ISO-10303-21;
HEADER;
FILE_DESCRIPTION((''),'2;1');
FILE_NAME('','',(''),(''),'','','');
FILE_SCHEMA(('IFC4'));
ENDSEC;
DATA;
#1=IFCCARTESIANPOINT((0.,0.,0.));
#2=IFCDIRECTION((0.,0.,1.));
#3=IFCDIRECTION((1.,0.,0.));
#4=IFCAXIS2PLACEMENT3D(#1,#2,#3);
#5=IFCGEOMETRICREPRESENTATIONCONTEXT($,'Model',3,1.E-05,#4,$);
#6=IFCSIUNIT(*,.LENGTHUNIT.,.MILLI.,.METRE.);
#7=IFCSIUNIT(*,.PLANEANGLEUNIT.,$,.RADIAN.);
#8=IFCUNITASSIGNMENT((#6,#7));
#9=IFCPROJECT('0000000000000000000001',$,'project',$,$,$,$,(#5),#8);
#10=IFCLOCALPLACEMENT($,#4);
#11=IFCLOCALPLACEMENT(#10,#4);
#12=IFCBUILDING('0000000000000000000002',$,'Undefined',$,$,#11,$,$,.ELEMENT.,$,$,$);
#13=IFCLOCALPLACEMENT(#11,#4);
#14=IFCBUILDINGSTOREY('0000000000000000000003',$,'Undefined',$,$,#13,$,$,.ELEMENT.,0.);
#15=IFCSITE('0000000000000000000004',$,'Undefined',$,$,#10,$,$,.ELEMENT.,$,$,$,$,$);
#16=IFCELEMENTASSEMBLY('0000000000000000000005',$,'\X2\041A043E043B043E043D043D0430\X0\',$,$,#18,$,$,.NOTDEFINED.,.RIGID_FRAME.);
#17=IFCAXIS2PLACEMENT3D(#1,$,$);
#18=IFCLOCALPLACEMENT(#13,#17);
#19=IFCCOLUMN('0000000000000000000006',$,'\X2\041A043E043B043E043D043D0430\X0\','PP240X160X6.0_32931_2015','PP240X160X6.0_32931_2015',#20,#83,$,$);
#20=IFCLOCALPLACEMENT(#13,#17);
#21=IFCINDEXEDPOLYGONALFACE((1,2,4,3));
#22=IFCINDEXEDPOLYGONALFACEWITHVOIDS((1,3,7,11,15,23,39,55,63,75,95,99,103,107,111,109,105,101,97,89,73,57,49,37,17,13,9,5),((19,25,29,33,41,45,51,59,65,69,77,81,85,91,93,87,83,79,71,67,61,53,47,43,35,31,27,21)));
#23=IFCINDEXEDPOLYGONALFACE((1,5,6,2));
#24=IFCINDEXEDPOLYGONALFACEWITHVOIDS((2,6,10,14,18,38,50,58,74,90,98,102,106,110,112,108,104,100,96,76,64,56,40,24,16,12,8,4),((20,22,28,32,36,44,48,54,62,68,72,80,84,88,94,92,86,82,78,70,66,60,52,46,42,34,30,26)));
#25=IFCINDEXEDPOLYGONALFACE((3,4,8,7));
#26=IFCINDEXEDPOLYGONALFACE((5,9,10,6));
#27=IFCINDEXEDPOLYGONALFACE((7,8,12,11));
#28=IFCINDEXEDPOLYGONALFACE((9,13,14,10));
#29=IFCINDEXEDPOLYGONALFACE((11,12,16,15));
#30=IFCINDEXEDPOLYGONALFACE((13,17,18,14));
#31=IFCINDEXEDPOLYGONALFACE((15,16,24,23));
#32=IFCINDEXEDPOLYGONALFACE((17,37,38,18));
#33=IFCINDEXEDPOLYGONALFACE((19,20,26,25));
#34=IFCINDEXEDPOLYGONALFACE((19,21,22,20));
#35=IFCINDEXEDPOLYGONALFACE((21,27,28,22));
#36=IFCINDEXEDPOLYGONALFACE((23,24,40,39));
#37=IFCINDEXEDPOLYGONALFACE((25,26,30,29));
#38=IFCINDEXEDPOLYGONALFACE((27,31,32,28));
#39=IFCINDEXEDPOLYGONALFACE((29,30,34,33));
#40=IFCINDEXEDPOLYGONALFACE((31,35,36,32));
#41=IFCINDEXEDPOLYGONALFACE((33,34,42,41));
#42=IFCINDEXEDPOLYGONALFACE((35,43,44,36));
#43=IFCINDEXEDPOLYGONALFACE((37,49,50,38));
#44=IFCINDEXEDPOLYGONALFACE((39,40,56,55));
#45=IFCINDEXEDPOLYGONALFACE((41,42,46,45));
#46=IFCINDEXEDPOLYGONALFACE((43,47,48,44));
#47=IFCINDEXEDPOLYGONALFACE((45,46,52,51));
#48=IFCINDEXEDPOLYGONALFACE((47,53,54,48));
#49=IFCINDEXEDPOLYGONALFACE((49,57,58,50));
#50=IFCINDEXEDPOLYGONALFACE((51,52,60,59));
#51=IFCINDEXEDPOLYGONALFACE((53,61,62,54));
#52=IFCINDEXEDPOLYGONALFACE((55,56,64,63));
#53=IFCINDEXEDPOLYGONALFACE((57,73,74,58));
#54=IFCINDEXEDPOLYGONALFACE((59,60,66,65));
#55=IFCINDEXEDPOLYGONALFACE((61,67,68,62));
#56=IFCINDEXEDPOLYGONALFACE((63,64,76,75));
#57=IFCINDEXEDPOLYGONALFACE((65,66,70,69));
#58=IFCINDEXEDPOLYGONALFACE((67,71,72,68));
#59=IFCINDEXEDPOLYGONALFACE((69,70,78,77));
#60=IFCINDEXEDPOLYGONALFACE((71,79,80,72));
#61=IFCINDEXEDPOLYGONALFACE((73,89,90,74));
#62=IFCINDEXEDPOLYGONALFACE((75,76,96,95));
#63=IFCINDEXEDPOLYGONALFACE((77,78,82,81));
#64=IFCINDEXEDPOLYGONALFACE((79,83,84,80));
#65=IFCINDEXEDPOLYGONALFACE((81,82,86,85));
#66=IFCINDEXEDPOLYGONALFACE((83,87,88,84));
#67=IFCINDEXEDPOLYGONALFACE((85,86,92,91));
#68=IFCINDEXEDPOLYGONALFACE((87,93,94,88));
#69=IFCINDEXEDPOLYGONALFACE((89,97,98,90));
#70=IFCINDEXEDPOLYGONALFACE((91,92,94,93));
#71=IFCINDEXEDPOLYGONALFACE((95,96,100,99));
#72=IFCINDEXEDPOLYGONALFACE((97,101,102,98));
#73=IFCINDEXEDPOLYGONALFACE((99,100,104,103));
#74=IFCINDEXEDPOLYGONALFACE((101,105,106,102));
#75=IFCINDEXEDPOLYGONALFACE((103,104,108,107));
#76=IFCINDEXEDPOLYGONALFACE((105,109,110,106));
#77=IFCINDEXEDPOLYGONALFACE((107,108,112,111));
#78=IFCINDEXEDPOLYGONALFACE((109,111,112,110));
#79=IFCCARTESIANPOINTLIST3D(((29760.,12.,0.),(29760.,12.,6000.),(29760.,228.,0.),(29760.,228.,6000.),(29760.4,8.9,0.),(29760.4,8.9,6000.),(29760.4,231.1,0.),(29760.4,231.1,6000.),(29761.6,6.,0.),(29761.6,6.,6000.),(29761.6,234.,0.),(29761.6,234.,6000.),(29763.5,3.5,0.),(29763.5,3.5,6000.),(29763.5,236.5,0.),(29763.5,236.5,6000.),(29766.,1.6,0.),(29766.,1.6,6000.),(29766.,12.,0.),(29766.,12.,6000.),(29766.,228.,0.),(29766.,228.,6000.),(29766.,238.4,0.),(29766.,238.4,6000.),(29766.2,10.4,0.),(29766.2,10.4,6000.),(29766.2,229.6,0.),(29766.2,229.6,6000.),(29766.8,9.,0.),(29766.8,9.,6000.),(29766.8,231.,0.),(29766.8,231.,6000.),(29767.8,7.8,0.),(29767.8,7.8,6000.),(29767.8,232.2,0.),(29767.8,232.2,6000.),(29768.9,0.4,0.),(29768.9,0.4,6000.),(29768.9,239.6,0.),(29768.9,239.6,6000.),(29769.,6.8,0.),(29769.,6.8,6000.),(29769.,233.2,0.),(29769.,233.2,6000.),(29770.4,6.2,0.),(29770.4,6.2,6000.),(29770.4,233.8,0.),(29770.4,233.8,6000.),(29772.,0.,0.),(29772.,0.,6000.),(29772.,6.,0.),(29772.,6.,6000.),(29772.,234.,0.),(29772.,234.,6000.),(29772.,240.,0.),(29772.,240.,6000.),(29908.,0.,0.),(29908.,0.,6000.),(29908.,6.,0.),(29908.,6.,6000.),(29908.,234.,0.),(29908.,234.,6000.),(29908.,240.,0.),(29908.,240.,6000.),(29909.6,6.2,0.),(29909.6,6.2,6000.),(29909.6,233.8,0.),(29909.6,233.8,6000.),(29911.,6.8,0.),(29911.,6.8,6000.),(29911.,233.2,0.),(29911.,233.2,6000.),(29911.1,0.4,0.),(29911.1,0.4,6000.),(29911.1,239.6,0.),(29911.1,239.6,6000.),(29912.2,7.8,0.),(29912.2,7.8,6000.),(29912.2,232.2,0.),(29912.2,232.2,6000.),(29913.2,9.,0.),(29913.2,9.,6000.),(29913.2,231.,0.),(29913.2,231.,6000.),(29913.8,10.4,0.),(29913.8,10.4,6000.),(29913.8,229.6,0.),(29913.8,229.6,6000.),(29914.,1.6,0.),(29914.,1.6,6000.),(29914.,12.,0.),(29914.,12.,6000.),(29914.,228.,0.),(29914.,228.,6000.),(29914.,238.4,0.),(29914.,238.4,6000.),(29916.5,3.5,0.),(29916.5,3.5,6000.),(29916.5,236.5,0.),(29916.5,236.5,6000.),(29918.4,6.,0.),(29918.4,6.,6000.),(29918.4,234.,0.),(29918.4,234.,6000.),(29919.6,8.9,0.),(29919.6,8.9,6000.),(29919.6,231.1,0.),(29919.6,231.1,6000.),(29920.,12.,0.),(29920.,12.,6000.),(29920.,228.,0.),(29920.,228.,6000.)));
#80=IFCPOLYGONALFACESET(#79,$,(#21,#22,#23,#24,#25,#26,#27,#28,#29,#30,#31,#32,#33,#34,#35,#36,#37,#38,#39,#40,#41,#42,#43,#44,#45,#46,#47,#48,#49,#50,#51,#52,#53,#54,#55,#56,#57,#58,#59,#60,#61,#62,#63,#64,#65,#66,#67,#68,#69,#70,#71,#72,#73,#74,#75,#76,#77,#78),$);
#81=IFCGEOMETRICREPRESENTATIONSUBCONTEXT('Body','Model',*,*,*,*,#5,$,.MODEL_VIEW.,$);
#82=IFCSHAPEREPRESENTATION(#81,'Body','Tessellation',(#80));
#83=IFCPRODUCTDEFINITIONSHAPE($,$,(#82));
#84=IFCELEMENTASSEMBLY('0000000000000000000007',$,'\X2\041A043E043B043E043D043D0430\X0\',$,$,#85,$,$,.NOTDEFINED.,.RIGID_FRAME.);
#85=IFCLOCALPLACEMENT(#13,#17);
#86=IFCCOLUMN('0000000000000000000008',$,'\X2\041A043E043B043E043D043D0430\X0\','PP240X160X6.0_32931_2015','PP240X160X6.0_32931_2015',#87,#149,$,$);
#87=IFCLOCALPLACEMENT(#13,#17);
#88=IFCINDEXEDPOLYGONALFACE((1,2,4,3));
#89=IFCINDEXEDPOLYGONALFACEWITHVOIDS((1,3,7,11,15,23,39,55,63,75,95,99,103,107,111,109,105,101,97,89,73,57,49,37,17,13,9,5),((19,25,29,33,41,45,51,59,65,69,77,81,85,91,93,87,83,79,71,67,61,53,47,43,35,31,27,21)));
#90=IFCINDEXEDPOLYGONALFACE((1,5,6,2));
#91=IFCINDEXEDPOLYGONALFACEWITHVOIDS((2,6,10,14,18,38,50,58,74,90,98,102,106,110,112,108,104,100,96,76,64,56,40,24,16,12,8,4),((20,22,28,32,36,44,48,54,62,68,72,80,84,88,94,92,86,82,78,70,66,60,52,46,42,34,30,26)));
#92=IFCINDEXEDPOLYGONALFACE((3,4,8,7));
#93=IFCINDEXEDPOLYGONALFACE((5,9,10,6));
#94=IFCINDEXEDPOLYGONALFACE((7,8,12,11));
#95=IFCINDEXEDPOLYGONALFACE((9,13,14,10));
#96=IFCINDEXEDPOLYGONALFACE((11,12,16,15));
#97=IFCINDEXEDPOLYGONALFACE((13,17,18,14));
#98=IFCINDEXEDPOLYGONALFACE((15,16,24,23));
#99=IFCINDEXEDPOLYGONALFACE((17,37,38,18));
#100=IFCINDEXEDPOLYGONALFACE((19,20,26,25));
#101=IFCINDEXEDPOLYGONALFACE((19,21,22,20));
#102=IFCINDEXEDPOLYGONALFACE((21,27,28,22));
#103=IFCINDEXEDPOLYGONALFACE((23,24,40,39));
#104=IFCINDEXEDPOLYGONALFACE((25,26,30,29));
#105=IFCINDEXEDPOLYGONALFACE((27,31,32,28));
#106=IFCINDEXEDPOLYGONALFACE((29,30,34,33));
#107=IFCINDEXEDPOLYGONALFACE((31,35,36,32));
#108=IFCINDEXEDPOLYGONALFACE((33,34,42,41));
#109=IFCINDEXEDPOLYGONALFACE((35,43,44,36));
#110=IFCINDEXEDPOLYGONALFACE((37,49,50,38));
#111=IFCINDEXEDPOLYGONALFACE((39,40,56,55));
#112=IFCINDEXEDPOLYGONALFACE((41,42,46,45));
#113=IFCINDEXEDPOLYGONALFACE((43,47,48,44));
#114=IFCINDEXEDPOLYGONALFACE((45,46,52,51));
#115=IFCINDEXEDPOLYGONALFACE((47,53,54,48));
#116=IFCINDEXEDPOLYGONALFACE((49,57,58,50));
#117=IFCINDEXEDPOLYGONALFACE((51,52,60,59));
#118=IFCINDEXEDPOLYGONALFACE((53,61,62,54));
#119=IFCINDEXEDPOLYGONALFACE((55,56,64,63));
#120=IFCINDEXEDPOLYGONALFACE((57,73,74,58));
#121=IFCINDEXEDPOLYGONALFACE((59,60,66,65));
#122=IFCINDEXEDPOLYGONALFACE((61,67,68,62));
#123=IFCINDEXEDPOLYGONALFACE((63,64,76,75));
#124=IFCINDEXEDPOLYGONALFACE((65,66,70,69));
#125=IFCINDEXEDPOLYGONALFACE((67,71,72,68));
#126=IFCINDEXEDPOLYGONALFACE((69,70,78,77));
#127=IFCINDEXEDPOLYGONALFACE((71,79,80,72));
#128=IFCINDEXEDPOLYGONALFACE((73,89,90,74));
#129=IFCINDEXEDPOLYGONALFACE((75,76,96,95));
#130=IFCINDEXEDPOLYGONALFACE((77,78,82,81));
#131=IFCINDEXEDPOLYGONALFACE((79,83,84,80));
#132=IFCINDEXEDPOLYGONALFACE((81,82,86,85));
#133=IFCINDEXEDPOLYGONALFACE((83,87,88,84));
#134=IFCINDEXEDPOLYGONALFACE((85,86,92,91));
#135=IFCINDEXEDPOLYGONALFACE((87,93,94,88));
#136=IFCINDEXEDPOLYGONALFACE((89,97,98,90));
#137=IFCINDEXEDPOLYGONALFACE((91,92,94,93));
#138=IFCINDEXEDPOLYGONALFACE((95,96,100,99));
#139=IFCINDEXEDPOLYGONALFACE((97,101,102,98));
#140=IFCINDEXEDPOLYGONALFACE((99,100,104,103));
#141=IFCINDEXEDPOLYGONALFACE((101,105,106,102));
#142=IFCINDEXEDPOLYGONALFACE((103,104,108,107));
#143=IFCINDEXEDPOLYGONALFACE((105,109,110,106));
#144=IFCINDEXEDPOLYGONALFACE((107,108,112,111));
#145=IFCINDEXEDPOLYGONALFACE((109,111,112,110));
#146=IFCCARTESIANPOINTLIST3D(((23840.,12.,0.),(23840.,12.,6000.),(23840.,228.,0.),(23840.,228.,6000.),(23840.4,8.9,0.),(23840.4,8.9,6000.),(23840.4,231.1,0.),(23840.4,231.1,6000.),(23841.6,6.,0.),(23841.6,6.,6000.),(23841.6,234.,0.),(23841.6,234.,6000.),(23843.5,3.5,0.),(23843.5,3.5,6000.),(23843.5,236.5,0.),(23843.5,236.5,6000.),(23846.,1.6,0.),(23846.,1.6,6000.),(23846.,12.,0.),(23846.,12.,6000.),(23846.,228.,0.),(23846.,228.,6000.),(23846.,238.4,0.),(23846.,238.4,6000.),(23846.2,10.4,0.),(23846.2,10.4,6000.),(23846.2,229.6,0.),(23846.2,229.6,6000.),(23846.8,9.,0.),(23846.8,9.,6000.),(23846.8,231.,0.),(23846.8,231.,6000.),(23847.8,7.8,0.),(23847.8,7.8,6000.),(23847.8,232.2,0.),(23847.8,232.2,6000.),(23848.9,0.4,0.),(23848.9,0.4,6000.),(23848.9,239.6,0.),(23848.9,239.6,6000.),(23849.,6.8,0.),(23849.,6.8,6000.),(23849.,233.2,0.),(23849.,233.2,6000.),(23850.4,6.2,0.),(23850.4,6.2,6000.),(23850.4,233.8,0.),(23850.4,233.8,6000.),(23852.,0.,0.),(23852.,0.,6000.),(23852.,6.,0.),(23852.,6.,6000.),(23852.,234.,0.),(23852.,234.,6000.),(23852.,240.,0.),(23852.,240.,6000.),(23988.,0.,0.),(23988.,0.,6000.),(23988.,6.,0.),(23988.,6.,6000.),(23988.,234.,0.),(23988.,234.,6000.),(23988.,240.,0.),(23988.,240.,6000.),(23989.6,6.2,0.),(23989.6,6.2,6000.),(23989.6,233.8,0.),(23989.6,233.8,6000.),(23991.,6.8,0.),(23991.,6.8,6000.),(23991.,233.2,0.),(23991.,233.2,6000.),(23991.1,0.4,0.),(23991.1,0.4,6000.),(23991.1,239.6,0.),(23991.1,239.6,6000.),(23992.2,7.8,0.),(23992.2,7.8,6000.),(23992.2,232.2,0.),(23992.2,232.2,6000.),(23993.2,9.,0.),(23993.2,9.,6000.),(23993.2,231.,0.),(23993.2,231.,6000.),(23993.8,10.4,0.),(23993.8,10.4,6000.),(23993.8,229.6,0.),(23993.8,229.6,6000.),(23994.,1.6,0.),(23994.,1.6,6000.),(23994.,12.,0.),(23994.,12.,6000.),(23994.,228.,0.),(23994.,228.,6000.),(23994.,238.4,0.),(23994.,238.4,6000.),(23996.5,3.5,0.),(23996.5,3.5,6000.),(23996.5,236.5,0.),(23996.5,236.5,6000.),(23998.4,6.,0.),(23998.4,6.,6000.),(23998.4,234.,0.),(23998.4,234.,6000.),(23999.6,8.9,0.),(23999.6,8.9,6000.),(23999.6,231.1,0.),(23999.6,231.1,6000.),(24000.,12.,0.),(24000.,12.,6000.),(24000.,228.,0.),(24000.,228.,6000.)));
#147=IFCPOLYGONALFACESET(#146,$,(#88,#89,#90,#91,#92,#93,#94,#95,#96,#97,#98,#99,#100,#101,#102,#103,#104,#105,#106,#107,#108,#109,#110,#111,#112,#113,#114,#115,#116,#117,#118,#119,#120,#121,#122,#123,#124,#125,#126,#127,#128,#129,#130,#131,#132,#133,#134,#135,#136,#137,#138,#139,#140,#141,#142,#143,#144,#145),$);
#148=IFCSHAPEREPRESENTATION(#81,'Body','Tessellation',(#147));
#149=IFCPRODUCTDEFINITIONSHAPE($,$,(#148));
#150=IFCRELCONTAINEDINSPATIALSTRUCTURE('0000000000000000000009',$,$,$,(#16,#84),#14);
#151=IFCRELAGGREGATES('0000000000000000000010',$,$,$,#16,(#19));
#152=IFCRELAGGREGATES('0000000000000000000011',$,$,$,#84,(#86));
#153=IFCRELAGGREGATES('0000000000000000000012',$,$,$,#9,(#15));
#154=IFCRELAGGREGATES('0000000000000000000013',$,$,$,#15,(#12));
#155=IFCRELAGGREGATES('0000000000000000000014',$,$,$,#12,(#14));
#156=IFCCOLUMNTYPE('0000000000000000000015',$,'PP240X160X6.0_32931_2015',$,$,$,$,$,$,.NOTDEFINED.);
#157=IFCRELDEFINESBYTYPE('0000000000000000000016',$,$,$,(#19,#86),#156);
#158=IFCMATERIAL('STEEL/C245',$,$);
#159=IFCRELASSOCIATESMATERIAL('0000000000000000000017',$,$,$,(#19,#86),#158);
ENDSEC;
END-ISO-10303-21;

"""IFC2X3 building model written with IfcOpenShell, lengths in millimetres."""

from ifc_helpers import new_model, si_unit, frame, origin_with_axes, origin_2d_with_axis, place, context, subcontext, project, spatial, hollow_rectangle, extrude, material, type_object, element, aggregate, save


model = new_model("IFC2X3")

# Units and contexts
model_context = context("Model", 3, precision=1e-05, world=origin_with_axes())
body_context = subcontext(model_context, "Body", "Model", "MODEL_VIEW")
ifc_project = project(units=[si_unit("LENGTHUNIT", "METRE", prefix="MILLI"), si_unit("PLANEANGLEUNIT", "RADIAN")], contexts=[model_context])

# Site, building, storey
site_placement = place(None, origin_with_axes())
site = spatial("IfcSite", under=ifc_project, at=site_placement, Name="Undefined", CompositionType="ELEMENT")
building_placement = place(site_placement, origin_with_axes())
building = spatial("IfcBuilding", under=site, at=building_placement, Name="Undefined", CompositionType="ELEMENT")
storey_placement = place(building_placement, origin_with_axes())
storey = spatial("IfcBuildingStorey", under=building, at=storey_placement, Name="Undefined", CompositionType="ELEMENT", Elevation=0.0)

# Element assemblies, columns
assembly_1_placement = place(storey_placement, origin_with_axes())
assembly_1 = element("IfcElementAssembly", 1, at=assembly_1_placement, inside=storey, Name="Колонна", AssemblyPlace="NOTDEFINED", PredefinedType="RIGID_FRAME")
ifc_material = material(Name="STEEL/C245")
column_type = type_object("IfcColumnType", Name="PP240X160X6.0_32931_2015", PredefinedType="NOTDEFINED")
column_1_placement = place(assembly_1_placement, frame((29840.0, 120.0, 0.0), z_axis=(0.0, 0.0, 1.0), x_axis=(0.0, 1.0, 0.0)))
column_1 = element("IfcColumn", 2, at=column_1_placement, type_object=column_type, material=ifc_material, Name="Колонна", Description="PP240X160X6.0_32931_2015", ObjectType="PP240X160X6.0_32931_2015", context=body_context, shape_type="SweptSolid", body=[
    extrude(hollow_rectangle(XDim=160.0, YDim=240.0, WallThickness=6.0, InnerFilletRadius=6.0, OuterFilletRadius=12.0, at=origin_2d_with_axis()), frame((0.0, 0.0, 6000.0), z_axis=(0.0, 0.0, -1.0), x_axis=(0.0, 1.0, 0.0)), (0.0, 0.0, 1.0), 6000.0),
])
aggregate(assembly_1, [column_1])
assembly_2_placement = place(storey_placement, origin_with_axes())
assembly_2 = element("IfcElementAssembly", 3, at=assembly_2_placement, inside=storey, Name="Колонна", AssemblyPlace="NOTDEFINED", PredefinedType="RIGID_FRAME")
column_2_placement = place(assembly_2_placement, frame((23920.0, 120.0, 0.0), z_axis=(0.0, 0.0, 1.0), x_axis=(0.0, 1.0, 0.0)))
column_2 = element("IfcColumn", 4, at=column_2_placement, type_object=column_type, material=ifc_material, Name="Колонна", Description="PP240X160X6.0_32931_2015", ObjectType="PP240X160X6.0_32931_2015", context=body_context, shape_type="SweptSolid", body=[
    extrude(hollow_rectangle(XDim=160.0, YDim=240.0, WallThickness=6.0, InnerFilletRadius=6.0, OuterFilletRadius=12.0, at=origin_2d_with_axis()), frame((0.0, 0.0, 6000.0), z_axis=(0.0, 0.0, -1.0), x_axis=(0.0, 1.0, 0.0)), (0.0, 0.0, 1.0), 6000.0),
])
aggregate(assembly_2, [column_2])

save(model, "model.ifc")
